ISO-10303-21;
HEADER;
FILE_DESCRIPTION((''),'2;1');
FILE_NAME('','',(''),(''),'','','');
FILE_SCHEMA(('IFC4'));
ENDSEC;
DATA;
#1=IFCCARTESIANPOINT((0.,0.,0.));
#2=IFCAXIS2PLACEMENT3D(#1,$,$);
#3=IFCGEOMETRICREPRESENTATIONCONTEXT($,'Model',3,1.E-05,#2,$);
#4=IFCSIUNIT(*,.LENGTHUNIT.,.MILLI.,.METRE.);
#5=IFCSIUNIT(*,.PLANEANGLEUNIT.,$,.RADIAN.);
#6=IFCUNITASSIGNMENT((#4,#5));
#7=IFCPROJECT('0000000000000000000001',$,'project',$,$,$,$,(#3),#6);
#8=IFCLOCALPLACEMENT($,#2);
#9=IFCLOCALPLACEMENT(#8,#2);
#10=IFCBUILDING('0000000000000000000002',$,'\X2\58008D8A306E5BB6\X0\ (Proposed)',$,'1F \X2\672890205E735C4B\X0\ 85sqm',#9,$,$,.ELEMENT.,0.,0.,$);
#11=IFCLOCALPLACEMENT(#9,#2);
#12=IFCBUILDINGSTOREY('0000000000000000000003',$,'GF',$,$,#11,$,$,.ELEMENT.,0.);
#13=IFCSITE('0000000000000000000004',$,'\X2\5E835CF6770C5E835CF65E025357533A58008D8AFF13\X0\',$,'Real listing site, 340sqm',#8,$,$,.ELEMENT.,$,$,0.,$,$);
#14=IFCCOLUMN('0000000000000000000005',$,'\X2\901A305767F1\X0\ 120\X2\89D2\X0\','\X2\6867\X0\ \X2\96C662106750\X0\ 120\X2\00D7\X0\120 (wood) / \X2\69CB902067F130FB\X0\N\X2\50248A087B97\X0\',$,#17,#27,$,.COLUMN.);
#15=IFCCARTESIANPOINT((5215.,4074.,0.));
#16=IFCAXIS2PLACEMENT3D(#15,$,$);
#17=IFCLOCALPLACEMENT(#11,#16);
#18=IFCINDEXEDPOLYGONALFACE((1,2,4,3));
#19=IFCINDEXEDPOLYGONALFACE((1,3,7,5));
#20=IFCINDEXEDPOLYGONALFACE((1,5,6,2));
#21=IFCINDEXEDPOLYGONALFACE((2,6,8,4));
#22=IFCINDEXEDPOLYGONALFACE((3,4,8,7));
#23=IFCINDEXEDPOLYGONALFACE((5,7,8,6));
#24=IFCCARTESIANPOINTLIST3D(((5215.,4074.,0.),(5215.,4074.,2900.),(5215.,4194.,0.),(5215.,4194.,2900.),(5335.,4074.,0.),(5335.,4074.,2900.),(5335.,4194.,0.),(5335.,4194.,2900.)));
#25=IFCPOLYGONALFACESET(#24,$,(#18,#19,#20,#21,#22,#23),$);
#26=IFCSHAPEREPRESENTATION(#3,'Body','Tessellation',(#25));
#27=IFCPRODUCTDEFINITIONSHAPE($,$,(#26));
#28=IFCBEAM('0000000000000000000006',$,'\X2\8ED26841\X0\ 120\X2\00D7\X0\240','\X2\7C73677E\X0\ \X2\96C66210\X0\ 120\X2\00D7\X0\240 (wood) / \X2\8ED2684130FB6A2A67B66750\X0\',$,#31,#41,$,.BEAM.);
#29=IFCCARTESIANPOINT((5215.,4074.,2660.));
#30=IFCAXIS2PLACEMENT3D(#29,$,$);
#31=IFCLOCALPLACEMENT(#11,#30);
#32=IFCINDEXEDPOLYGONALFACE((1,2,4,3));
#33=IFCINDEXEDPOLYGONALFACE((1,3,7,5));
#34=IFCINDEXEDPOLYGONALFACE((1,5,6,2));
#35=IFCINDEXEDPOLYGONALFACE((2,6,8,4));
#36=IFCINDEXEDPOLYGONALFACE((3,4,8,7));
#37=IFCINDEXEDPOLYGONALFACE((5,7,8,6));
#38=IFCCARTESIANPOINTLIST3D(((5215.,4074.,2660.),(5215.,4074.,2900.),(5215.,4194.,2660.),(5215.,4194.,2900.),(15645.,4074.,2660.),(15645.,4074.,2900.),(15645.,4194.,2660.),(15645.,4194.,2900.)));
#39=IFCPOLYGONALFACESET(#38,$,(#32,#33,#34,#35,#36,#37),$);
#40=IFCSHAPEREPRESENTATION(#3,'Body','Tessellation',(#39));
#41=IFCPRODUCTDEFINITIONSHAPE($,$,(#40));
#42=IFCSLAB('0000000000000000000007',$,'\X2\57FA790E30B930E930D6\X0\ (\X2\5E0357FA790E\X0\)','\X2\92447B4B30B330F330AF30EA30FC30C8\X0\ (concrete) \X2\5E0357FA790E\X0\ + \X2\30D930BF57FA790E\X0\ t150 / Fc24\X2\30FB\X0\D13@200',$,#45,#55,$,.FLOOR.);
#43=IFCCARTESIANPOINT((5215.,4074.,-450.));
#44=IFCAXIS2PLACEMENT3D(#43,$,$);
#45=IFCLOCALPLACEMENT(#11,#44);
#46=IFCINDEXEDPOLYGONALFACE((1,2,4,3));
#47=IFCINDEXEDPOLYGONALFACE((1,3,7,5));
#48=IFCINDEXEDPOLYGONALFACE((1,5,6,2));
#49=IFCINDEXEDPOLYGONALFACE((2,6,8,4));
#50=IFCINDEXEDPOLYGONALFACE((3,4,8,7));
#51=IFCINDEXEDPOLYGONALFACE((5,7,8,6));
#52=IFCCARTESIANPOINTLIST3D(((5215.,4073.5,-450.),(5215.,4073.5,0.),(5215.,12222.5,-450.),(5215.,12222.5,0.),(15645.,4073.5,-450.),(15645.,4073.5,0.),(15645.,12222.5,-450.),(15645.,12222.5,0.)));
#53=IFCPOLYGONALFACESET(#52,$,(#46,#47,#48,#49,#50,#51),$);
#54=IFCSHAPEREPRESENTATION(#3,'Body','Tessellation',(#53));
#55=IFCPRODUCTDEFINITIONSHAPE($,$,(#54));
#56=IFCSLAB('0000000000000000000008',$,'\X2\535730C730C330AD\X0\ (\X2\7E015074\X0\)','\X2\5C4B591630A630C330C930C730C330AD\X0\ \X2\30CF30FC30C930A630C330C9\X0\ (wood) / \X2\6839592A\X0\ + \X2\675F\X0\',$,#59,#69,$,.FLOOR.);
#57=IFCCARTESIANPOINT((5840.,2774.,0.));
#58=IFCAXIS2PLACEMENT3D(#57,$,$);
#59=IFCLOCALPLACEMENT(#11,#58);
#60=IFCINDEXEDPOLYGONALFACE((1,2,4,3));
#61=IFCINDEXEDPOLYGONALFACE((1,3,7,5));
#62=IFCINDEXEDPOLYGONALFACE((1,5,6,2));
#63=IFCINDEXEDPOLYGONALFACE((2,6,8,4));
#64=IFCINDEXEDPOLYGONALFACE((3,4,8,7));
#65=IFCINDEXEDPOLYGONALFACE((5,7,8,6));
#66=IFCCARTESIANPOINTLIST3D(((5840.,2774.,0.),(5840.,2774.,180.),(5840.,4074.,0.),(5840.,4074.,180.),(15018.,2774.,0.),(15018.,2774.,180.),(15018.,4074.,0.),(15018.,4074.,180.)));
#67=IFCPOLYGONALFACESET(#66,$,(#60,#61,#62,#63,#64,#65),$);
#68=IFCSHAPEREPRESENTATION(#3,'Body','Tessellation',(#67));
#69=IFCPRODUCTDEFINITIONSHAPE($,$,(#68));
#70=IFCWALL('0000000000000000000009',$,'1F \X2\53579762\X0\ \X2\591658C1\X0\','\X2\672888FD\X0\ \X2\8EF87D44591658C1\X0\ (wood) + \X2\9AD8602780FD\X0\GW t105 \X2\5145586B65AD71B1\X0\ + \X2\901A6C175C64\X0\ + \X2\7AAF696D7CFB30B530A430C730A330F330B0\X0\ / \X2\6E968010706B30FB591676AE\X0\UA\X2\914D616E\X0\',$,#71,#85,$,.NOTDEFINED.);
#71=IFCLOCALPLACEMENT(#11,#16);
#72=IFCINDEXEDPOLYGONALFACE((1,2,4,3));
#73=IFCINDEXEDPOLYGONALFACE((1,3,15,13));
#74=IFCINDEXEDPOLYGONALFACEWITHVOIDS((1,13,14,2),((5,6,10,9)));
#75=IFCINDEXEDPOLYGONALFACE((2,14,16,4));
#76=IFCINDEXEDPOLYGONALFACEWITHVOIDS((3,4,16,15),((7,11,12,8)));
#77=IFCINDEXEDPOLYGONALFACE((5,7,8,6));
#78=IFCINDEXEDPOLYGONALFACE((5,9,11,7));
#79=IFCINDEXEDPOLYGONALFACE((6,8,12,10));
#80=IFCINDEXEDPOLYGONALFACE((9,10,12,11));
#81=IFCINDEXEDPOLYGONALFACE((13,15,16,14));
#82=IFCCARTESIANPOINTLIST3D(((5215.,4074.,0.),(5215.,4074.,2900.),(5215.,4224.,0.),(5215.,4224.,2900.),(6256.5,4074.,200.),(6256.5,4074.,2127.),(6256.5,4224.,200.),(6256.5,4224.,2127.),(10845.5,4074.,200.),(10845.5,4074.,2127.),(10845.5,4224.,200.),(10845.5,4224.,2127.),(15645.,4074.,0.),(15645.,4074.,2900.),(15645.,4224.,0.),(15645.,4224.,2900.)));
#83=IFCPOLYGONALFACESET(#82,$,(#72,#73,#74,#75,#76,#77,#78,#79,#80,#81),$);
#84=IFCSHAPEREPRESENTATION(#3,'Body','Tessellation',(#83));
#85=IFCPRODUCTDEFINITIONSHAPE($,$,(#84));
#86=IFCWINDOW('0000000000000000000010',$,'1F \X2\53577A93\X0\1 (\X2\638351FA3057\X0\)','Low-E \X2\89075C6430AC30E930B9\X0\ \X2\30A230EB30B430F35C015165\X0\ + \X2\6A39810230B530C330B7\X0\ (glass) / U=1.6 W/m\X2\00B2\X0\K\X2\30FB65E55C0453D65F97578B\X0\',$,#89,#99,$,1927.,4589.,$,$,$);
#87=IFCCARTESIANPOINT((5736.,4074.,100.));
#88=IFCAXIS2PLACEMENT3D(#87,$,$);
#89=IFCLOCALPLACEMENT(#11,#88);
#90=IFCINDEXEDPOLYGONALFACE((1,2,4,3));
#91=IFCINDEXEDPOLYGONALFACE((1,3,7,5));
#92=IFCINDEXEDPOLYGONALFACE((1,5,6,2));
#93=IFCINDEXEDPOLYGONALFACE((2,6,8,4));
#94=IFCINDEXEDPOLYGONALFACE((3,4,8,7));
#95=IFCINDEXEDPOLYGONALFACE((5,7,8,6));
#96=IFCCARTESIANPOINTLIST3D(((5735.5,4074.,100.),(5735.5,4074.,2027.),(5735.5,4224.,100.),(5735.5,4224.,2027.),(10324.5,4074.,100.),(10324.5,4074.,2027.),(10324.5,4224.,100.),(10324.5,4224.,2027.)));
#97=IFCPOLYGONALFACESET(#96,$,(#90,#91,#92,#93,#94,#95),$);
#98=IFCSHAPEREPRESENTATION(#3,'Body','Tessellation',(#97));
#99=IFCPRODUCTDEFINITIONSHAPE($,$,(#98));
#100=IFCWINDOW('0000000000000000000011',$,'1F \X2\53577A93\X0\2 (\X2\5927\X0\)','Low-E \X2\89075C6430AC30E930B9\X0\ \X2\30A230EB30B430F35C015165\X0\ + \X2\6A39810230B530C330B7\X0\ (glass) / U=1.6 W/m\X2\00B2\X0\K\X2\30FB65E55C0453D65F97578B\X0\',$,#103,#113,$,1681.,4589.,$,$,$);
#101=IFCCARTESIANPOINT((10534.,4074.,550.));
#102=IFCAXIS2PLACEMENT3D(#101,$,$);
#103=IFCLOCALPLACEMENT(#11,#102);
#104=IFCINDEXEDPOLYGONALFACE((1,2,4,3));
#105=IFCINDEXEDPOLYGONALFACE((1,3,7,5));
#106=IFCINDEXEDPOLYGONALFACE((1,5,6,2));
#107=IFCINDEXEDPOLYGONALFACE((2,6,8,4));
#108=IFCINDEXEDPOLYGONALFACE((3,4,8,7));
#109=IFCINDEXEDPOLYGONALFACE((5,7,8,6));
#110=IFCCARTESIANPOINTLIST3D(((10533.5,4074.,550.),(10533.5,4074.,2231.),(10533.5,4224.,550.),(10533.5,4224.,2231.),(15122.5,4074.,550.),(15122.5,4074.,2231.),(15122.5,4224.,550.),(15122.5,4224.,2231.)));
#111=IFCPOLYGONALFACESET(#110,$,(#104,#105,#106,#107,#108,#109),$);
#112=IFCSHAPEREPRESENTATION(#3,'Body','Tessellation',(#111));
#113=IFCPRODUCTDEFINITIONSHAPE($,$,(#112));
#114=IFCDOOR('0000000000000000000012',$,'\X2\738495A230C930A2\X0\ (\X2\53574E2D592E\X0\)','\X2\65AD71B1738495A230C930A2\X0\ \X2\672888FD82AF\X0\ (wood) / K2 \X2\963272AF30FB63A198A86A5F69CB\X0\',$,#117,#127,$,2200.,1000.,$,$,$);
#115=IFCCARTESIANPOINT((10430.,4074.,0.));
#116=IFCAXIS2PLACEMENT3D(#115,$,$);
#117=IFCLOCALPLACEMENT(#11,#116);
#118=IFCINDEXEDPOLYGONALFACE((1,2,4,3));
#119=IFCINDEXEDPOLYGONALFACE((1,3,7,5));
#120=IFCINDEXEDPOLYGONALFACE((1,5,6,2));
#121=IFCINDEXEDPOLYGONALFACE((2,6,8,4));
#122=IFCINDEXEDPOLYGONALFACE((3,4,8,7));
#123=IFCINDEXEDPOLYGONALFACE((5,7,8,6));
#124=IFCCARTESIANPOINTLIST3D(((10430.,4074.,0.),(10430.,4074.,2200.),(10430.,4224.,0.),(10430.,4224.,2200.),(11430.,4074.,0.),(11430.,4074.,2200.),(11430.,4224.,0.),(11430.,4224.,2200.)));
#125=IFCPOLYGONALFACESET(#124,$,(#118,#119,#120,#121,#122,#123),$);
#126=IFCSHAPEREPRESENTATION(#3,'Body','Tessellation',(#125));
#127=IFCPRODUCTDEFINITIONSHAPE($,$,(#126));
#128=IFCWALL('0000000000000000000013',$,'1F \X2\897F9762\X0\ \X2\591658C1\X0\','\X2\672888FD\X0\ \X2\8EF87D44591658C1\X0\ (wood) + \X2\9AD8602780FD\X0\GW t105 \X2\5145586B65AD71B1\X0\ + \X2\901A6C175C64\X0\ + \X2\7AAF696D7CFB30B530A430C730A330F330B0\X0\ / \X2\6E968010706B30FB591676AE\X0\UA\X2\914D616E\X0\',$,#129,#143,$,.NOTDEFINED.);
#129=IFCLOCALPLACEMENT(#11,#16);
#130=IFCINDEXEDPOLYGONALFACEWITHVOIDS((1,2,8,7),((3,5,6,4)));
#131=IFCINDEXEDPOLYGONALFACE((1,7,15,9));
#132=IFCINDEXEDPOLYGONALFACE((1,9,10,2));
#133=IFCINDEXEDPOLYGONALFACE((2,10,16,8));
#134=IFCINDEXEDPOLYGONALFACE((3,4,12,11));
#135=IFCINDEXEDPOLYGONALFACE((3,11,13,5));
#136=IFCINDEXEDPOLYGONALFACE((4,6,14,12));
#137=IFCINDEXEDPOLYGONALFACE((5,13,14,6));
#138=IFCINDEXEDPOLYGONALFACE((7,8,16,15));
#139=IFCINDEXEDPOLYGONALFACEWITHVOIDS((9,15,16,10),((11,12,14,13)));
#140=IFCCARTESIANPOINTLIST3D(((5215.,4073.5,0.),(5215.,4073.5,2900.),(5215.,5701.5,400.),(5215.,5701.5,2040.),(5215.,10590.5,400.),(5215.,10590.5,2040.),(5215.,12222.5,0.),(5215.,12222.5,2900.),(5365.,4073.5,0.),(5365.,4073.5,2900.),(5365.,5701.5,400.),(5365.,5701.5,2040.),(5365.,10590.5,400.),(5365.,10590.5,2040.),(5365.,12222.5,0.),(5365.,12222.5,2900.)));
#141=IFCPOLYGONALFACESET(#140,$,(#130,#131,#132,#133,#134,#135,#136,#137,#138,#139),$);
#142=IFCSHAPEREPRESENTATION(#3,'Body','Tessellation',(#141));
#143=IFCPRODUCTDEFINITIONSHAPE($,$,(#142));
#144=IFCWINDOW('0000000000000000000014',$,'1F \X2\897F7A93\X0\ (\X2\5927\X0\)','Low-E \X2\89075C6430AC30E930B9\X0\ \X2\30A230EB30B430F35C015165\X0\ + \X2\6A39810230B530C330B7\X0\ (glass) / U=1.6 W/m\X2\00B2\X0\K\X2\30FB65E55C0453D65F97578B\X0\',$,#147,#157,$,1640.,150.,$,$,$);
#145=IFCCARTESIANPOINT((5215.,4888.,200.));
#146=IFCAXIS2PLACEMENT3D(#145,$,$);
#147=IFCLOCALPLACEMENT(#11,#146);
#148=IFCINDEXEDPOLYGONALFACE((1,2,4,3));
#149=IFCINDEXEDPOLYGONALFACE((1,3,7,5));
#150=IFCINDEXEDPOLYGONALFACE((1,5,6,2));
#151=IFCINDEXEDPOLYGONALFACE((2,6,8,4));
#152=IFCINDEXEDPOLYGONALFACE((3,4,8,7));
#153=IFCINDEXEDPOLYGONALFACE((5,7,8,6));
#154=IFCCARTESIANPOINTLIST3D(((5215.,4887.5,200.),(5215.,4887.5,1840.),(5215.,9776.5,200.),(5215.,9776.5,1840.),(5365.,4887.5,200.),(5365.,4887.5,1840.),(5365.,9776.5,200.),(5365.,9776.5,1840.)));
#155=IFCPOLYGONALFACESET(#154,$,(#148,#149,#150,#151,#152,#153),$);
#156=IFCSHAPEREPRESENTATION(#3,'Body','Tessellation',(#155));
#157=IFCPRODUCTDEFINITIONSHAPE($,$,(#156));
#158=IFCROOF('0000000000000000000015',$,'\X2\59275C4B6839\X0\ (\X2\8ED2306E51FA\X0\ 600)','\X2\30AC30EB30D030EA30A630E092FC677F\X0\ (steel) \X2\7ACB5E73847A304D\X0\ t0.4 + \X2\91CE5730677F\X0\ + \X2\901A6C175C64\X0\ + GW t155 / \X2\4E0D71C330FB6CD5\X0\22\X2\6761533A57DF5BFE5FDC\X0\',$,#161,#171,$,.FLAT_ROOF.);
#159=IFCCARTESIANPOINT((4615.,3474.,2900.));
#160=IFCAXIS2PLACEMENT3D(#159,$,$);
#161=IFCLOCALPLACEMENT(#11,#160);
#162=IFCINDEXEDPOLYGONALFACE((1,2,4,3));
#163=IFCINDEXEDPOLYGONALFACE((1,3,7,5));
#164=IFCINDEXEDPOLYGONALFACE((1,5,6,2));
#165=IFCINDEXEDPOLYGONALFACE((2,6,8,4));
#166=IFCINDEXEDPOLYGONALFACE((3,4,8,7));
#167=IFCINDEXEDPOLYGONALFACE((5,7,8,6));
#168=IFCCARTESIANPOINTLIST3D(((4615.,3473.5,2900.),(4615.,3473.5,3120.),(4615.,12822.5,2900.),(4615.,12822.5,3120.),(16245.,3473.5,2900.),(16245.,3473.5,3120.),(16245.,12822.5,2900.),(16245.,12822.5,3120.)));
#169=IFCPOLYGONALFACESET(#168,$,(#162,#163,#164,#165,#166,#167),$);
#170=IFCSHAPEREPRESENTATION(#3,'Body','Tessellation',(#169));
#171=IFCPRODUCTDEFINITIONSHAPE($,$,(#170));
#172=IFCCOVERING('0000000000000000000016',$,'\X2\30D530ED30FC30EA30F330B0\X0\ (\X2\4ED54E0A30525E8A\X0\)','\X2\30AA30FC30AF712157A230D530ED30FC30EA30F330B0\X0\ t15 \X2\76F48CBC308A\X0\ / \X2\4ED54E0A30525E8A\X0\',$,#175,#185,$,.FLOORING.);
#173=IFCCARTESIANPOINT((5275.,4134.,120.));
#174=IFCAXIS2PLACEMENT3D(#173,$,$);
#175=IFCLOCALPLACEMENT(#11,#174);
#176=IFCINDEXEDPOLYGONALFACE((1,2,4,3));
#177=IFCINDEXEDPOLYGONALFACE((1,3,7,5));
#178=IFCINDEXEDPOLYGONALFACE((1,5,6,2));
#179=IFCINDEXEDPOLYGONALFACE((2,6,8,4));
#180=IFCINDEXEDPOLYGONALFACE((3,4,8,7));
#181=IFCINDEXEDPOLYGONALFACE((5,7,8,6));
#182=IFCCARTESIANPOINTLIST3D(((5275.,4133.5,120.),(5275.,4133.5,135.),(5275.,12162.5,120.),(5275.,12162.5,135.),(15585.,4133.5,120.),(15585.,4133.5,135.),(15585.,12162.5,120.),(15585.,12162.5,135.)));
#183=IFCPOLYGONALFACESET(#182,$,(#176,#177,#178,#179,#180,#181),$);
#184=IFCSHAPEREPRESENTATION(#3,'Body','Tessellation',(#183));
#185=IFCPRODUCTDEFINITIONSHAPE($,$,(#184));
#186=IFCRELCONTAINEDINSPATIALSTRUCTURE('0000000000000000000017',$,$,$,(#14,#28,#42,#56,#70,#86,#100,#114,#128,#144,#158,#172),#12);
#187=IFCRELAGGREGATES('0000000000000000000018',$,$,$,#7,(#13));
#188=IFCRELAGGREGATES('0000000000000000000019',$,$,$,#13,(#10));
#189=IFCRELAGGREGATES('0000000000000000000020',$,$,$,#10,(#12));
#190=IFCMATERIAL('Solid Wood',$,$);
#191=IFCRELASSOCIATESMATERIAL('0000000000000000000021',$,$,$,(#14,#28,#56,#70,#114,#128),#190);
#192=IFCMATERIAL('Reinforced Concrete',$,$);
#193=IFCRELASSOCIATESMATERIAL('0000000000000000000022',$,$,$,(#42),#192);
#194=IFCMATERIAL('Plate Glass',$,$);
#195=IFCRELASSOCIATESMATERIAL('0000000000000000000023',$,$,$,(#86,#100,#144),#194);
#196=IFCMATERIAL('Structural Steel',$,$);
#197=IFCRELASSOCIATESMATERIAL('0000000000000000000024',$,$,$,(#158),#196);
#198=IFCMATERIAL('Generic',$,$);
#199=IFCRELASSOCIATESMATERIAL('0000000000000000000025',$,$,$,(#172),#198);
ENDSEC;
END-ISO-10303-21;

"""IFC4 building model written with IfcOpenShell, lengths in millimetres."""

from ifc_helpers import new_model, si_unit, frame, frame_2d, origin, place, context, project, spatial, rectangle, extrude, material, element, fill, save


model = new_model("IFC4")

# Units and contexts
model_context = context("Model", 3, precision=1e-05, world=origin())
ifc_project = project(units=[si_unit("LENGTHUNIT", "METRE", prefix="MILLI"), si_unit("PLANEANGLEUNIT", "RADIAN")], contexts=[model_context])

# Site, building, storey
site_placement = place(None, origin())
site = spatial("IfcSite", under=ifc_project, at=site_placement, Name="広島県広島市南区堀越３", ObjectType="Real listing site, 340sqm", CompositionType="ELEMENT", RefElevation=0.0)
building_placement = place(site_placement, origin())
building = spatial("IfcBuilding", under=site, at=building_placement, Name="堀越の家 (Proposed)", ObjectType="1F 木造平屋 85sqm", CompositionType="ELEMENT", ElevationOfRefHeight=0.0, ElevationOfTerrain=0.0)
storey_placement = place(building_placement, origin())
storey = spatial("IfcBuildingStorey", under=building, at=storey_placement, Name="GF", CompositionType="ELEMENT", Elevation=0.0)

# Column
ifc_material_1 = material(Name="Solid Wood")
column_placement = place(storey_placement, frame((5215.0, 4074.0, 0.0)))
element("IfcColumn", 1, at=column_placement, inside=storey, material=ifc_material_1, Name="通し柱 120角", Description="桧 集成材 120×120 (wood) / 構造柱・N値計算", PredefinedType="COLUMN", context=model_context, shape_type="SweptSolid", body=[
    extrude(rectangle(XDim=120.0, YDim=120.0, at=frame_2d((60.0, 60.0))), frame((5215.0, 4074.0, 0.0)), (0.0, 0.0, 1.0), 2900.0),
])

# Beam
beam_1_placement = place(storey_placement, frame((5215.0, 4074.0, 2660.0)))
element("IfcBeam", 2, at=beam_1_placement, inside=storey, material=ifc_material_1, Name="軒桁 120×240", Description="米松 集成 120×240 (wood) / 軒桁・横架材", PredefinedType="BEAM", context=model_context, shape_type="SweptSolid", body=[
    extrude(rectangle(XDim=10430.0, YDim=120.0, at=frame_2d((5215.0, 60.0))), frame((5215.0, 4074.0, 2660.0)), (0.0, 0.0, 1.0), 240.0),
])

# Slabs
ifc_material_2 = material(Name="Reinforced Concrete")
slab_1_placement = place(storey_placement, frame((5215.0, 4074.0, -450.0)))
element("IfcSlab", 3, at=slab_1_placement, inside=storey, material=ifc_material_2, Name="基礎スラブ (布基礎)", Description="鉄筋コンクリート (concrete) 布基礎 + ベタ基礎 t150 / Fc24・D13@200", PredefinedType="FLOOR", context=model_context, shape_type="SweptSolid", body=[
    extrude(rectangle(XDim=10430.0, YDim=8149.0, at=frame_2d((5215.0, 4074.0))), frame((5215.0, 4074.0, -450.0)), (0.0, 0.0, 1.0), 450.0),
])
slab_2_placement = place(storey_placement, frame((5840.0, 2774.0, 0.0)))
element("IfcSlab", 4, at=slab_2_placement, inside=storey, material=ifc_material_1, Name="南デッキ (縁側)", Description="屋外ウッドデッキ ハードウッド (wood) / 根太 + 束", PredefinedType="FLOOR", context=model_context, shape_type="SweptSolid", body=[
    extrude(rectangle(XDim=9178.0, YDim=1300.0, at=frame_2d((4589.0, 650.0))), frame((5840.0, 2774.0, 0.0)), (0.0, 0.0, 1.0), 180.0),
])

# Wall, openings, windows, door
wall_1_placement = place(storey_placement, frame((5215.0, 4074.0, 0.0)))
wall_1 = element("IfcWall", 5, at=wall_1_placement, inside=storey, material=ifc_material_1, Name="1F 南面 外壁", Description="木製 軸組外壁 (wood) + 高性能GW t105 充填断熱 + 通気層 + 窯業系サイディング / 準耐火・外皮UA配慮", PredefinedType="NOTDEFINED", context=model_context, shape_type="SweptSolid", body=[
    extrude(rectangle(XDim=10430.0, YDim=150.0, at=frame_2d((5215.0, 75.0))), frame((5215.0, 4074.0, 0.0)), (0.0, 0.0, 1.0), 2900.0),
])
opening_1_placement = place(storey_placement, frame((5736.0, 4074.0, 100.0)))
opening_1 = element("IfcOpeningElement", 6, at=opening_1_placement, cuts=wall_1, PredefinedType="NOTDEFINED", context=model_context, shape_type="SweptSolid", body=[
    extrude(rectangle(XDim=4589.0, YDim=150.0, at=frame_2d((2294.0, 75.0))), frame((5736.0, 4074.0, 100.0)), (0.0, 0.0, 1.0), 1927.0),
])
opening_2_placement = place(storey_placement, frame((10534.0, 4074.0, 550.0)))
opening_2 = element("IfcOpeningElement", 7, at=opening_2_placement, cuts=wall_1, PredefinedType="NOTDEFINED", context=model_context, shape_type="SweptSolid", body=[
    extrude(rectangle(XDim=4589.0, YDim=150.0, at=frame_2d((2294.0, 75.0))), frame((10534.0, 4074.0, 550.0)), (0.0, 0.0, 1.0), 1681.0),
])
opening_3_placement = place(storey_placement, frame((10430.0, 4074.0, 0.0)))
opening_3 = element("IfcOpeningElement", 8, at=opening_3_placement, cuts=wall_1, PredefinedType="NOTDEFINED", context=model_context, shape_type="SweptSolid", body=[
    extrude(rectangle(XDim=1000.0, YDim=150.0, at=frame_2d((500.0, 75.0))), frame((10430.0, 4074.0, 0.0)), (0.0, 0.0, 1.0), 2200.0),
])
ifc_material_3 = material(Name="Plate Glass")
window_1_placement = place(storey_placement, frame((5736.0, 4074.0, 100.0)))
window_1 = element("IfcWindow", 9, at=window_1_placement, inside=storey, material=ifc_material_3, Name="1F 南窓1 (掃出し)", Description="Low-E 複層ガラス アルゴン封入 + 樹脂サッシ (glass) / U=1.6 W/m²K・日射取得型", OverallHeight=1927.0, OverallWidth=4589.0, context=model_context, shape_type="SweptSolid", body=[
    extrude(rectangle(XDim=4589.0, YDim=150.0, at=frame_2d((2294.0, 75.0))), frame((5736.0, 4074.0, 100.0)), (0.0, 0.0, 1.0), 1927.0),
])
fill(opening_1, window_1)
window_2_placement = place(storey_placement, frame((10534.0, 4074.0, 550.0)))
window_2 = element("IfcWindow", 10, at=window_2_placement, inside=storey, material=ifc_material_3, Name="1F 南窓2 (大)", Description="Low-E 複層ガラス アルゴン封入 + 樹脂サッシ (glass) / U=1.6 W/m²K・日射取得型", OverallHeight=1681.0, OverallWidth=4589.0, context=model_context, shape_type="SweptSolid", body=[
    extrude(rectangle(XDim=4589.0, YDim=150.0, at=frame_2d((2294.0, 75.0))), frame((10534.0, 4074.0, 550.0)), (0.0, 0.0, 1.0), 1681.0),
])
fill(opening_2, window_2)
door_placement = place(storey_placement, frame((10430.0, 4074.0, 0.0)))
door = element("IfcDoor", 11, at=door_placement, inside=storey, material=ifc_material_1, Name="玄関ドア (南中央)", Description="断熱玄関ドア 木製芯 (wood) / K2 防犯・採風機構", OverallHeight=2200.0, OverallWidth=1000.0, context=model_context, shape_type="SweptSolid", body=[
    extrude(rectangle(XDim=1000.0, YDim=150.0, at=frame_2d((500.0, 75.0))), frame((10430.0, 4074.0, 0.0)), (0.0, 0.0, 1.0), 2200.0),
])
fill(opening_3, door)

# Wall, opening, window
wall_2_placement = place(storey_placement, frame((5215.0, 4074.0, 0.0)))
wall_2 = element("IfcWall", 12, at=wall_2_placement, inside=storey, material=ifc_material_1, Name="1F 西面 外壁", Description="木製 軸組外壁 (wood) + 高性能GW t105 充填断熱 + 通気層 + 窯業系サイディング / 準耐火・外皮UA配慮", PredefinedType="NOTDEFINED", context=model_context, shape_type="SweptSolid", body=[
    extrude(rectangle(XDim=150.0, YDim=8149.0, at=frame_2d((75.0, 4074.0))), frame((5215.0, 4074.0, 0.0)), (0.0, 0.0, 1.0), 2900.0),
])
opening_4_placement = place(storey_placement, frame((5215.0, 4888.0, 200.0)))
opening_4 = element("IfcOpeningElement", 13, at=opening_4_placement, cuts=wall_2, PredefinedType="NOTDEFINED", context=model_context, shape_type="SweptSolid", body=[
    extrude(rectangle(XDim=150.0, YDim=4889.0, at=frame_2d((75.0, 2444.0))), frame((5215.0, 4888.0, 200.0)), (0.0, 0.0, 1.0), 1640.0),
])
window_3_placement = place(storey_placement, frame((5215.0, 4888.0, 200.0)))
window_3 = element("IfcWindow", 14, at=window_3_placement, inside=storey, material=ifc_material_3, Name="1F 西窓 (大)", Description="Low-E 複層ガラス アルゴン封入 + 樹脂サッシ (glass) / U=1.6 W/m²K・日射取得型", OverallHeight=1640.0, OverallWidth=150.0, context=model_context, shape_type="SweptSolid", body=[
    extrude(rectangle(XDim=150.0, YDim=4889.0, at=frame_2d((75.0, 2444.0))), frame((5215.0, 4888.0, 200.0)), (0.0, 0.0, 1.0), 1640.0),
])
fill(opening_4, window_3)

# Roof
ifc_material_4 = material(Name="Structural Steel")
roof_placement = place(storey_placement, frame((4615.0, 3474.0, 2900.0)))
element("IfcRoof", 15, at=roof_placement, inside=storey, material=ifc_material_4, Name="大屋根 (軒の出 600)", Description="ガルバリウム鋼板 (steel) 立平葺き t0.4 + 野地板 + 通気層 + GW t155 / 不燃・法22条区域対応", PredefinedType="FLAT_ROOF", context=model_context, shape_type="SweptSolid", body=[
    extrude(rectangle(XDim=11630.0, YDim=9349.0, at=frame_2d((5815.0, 4674.0))), frame((4615.0, 3474.0, 2900.0)), (0.0, 0.0, 1.0), 220.0),
])

# Covering
ifc_material_5 = material(Name="Generic")
covering_1_placement = place(storey_placement, frame((5275.0, 4134.0, 120.0)))
element("IfcCovering", 16, at=covering_1_placement, inside=storey, material=ifc_material_5, Name="フローリング (仕上げ床)", Description="オーク無垢フローリング t15 直貼り / 仕上げ床", PredefinedType="FLOORING", context=model_context, shape_type="SweptSolid", body=[
    extrude(rectangle(XDim=10310.0, YDim=8029.0, at=frame_2d((5155.0, 4014.0))), frame((5275.0, 4134.0, 120.0)), (0.0, 0.0, 1.0), 15.0),
])

save(model, "model.ifc")
